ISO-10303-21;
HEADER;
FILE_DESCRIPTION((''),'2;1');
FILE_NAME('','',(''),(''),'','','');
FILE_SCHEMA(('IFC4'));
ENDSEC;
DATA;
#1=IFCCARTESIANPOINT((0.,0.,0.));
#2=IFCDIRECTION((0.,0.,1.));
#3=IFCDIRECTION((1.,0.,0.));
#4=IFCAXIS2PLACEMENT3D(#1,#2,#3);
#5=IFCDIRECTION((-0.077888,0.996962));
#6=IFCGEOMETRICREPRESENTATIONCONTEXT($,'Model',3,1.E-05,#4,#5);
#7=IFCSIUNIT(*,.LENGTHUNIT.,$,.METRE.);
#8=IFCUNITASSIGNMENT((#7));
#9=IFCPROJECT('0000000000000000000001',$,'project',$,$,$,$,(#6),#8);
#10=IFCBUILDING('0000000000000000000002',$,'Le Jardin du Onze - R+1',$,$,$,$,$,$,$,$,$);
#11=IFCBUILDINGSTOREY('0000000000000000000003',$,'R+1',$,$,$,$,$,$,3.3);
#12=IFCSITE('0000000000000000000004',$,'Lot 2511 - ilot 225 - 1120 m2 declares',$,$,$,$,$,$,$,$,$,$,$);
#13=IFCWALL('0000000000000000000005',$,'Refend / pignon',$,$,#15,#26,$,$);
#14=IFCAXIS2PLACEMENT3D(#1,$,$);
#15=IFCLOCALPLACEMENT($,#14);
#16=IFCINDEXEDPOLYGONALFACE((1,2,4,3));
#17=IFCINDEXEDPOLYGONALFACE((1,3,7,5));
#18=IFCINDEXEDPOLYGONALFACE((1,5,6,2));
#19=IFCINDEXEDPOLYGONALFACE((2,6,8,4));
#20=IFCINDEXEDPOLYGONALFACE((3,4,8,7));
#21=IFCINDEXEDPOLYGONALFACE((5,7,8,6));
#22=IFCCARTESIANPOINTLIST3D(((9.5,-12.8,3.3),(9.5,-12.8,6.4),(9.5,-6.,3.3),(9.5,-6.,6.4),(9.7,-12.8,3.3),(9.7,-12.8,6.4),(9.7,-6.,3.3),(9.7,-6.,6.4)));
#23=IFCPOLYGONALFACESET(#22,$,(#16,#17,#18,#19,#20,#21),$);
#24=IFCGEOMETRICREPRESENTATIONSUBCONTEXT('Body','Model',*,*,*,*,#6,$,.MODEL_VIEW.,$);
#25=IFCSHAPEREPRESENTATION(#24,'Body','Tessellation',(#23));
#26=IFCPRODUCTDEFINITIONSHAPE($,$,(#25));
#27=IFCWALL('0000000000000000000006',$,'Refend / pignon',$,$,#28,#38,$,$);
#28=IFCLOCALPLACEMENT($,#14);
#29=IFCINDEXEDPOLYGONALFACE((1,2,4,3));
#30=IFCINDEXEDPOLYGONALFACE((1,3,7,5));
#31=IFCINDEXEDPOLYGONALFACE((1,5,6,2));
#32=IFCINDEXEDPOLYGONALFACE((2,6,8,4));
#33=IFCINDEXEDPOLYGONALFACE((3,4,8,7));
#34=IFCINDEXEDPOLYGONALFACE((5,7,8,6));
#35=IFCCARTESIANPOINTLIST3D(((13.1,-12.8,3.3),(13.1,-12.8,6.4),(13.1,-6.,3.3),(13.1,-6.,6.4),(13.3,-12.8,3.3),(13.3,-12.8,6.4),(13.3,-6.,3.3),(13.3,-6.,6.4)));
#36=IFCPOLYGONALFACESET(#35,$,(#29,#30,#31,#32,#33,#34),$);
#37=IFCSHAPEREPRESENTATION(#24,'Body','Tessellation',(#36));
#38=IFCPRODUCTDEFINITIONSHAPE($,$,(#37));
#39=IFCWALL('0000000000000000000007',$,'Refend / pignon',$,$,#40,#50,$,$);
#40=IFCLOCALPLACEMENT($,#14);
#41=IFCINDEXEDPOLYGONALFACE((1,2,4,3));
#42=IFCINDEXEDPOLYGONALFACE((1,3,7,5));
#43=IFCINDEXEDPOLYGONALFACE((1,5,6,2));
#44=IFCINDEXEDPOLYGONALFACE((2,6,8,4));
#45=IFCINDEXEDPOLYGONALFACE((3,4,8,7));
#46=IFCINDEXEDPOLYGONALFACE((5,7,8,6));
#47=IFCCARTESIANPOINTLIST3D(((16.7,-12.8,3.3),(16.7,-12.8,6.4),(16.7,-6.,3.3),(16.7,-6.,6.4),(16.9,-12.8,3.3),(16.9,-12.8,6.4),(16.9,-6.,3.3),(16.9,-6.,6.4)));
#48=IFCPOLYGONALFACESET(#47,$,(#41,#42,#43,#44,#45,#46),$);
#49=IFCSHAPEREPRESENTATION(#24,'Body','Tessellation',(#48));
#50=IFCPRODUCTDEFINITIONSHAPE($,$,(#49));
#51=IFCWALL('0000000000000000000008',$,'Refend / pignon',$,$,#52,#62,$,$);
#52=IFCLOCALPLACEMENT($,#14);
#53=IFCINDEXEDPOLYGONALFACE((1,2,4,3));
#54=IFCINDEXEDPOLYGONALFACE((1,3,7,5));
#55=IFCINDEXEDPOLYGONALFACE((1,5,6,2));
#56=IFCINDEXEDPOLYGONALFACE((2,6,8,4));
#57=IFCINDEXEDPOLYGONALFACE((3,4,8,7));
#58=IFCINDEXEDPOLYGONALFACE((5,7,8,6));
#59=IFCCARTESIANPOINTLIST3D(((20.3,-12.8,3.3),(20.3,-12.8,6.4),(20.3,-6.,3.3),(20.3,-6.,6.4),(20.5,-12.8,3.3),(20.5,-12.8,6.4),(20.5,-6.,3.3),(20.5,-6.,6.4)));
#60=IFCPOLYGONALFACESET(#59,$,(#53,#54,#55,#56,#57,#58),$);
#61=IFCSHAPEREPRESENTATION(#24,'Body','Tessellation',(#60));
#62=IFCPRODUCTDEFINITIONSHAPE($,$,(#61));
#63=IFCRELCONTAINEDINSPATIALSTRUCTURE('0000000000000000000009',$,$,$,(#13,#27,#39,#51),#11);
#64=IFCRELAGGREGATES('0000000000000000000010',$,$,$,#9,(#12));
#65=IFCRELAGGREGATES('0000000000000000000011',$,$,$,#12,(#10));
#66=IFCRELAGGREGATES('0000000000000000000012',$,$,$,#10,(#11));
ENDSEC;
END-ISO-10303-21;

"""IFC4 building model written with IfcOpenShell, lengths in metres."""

from ifc_helpers import new_model, si_unit, direction, frame, origin_with_axes, place, context, subcontext, project, spatial, polyline, outline, extrude, element, save


model = new_model("IFC4")

# Units and contexts
model_context = context("Model", 3, precision=1e-05, world=origin_with_axes(), true_north=direction((-0.077888, 0.996962)))
body_context = subcontext(model_context, "Body", "Model", "MODEL_VIEW")
ifc_project = project(units=[si_unit("LENGTHUNIT", "METRE")], contexts=[model_context])

# Site, building, storey
site = spatial("IfcSite", under=ifc_project, Name="Lot 2511 - ilot 225 - 1120 m2 declares")
building = spatial("IfcBuilding", under=site, Name="Le Jardin du Onze - R+1")
storey = spatial("IfcBuildingStorey", under=building, Name="R+1", Elevation=3.3)

# Walls
wall_1_placement = place(None, origin_with_axes())
element("IfcWall", 1, at=wall_1_placement, inside=storey, Name="Refend / pignon", context=body_context, shape_type="SweptSolid", body=[
    extrude(outline(polyline([(9.7, -12.8), (9.7, -6.0), (9.5, -6.0), (9.5, -12.8), (9.7, -12.8)])), frame((0.0, 0.0, 3.3)), (0.0, 0.0, 1.0), 3.1),
])
wall_2_placement = place(None, origin_with_axes())
element("IfcWall", 2, at=wall_2_placement, inside=storey, Name="Refend / pignon", context=body_context, shape_type="SweptSolid", body=[
    extrude(outline(polyline([(13.3, -12.8), (13.3, -6.0), (13.1, -6.0), (13.1, -12.8), (13.3, -12.8)])), frame((0.0, 0.0, 3.3)), (0.0, 0.0, 1.0), 3.1),
])
wall_3_placement = place(None, origin_with_axes())
element("IfcWall", 3, at=wall_3_placement, inside=storey, Name="Refend / pignon", context=body_context, shape_type="SweptSolid", body=[
    extrude(outline(polyline([(16.9, -12.8), (16.9, -6.0), (16.7, -6.0), (16.7, -12.8), (16.9, -12.8)])), frame((0.0, 0.0, 3.3)), (0.0, 0.0, 1.0), 3.1),
])
wall_4_placement = place(None, origin_with_axes())
element("IfcWall", 4, at=wall_4_placement, inside=storey, Name="Refend / pignon", context=body_context, shape_type="SweptSolid", body=[
    extrude(outline(polyline([(20.5, -12.8), (20.5, -6.0), (20.3, -6.0), (20.3, -12.8), (20.5, -12.8)])), frame((0.0, 0.0, 3.3)), (0.0, 0.0, 1.0), 3.1),
])

save(model, "model.ifc")
